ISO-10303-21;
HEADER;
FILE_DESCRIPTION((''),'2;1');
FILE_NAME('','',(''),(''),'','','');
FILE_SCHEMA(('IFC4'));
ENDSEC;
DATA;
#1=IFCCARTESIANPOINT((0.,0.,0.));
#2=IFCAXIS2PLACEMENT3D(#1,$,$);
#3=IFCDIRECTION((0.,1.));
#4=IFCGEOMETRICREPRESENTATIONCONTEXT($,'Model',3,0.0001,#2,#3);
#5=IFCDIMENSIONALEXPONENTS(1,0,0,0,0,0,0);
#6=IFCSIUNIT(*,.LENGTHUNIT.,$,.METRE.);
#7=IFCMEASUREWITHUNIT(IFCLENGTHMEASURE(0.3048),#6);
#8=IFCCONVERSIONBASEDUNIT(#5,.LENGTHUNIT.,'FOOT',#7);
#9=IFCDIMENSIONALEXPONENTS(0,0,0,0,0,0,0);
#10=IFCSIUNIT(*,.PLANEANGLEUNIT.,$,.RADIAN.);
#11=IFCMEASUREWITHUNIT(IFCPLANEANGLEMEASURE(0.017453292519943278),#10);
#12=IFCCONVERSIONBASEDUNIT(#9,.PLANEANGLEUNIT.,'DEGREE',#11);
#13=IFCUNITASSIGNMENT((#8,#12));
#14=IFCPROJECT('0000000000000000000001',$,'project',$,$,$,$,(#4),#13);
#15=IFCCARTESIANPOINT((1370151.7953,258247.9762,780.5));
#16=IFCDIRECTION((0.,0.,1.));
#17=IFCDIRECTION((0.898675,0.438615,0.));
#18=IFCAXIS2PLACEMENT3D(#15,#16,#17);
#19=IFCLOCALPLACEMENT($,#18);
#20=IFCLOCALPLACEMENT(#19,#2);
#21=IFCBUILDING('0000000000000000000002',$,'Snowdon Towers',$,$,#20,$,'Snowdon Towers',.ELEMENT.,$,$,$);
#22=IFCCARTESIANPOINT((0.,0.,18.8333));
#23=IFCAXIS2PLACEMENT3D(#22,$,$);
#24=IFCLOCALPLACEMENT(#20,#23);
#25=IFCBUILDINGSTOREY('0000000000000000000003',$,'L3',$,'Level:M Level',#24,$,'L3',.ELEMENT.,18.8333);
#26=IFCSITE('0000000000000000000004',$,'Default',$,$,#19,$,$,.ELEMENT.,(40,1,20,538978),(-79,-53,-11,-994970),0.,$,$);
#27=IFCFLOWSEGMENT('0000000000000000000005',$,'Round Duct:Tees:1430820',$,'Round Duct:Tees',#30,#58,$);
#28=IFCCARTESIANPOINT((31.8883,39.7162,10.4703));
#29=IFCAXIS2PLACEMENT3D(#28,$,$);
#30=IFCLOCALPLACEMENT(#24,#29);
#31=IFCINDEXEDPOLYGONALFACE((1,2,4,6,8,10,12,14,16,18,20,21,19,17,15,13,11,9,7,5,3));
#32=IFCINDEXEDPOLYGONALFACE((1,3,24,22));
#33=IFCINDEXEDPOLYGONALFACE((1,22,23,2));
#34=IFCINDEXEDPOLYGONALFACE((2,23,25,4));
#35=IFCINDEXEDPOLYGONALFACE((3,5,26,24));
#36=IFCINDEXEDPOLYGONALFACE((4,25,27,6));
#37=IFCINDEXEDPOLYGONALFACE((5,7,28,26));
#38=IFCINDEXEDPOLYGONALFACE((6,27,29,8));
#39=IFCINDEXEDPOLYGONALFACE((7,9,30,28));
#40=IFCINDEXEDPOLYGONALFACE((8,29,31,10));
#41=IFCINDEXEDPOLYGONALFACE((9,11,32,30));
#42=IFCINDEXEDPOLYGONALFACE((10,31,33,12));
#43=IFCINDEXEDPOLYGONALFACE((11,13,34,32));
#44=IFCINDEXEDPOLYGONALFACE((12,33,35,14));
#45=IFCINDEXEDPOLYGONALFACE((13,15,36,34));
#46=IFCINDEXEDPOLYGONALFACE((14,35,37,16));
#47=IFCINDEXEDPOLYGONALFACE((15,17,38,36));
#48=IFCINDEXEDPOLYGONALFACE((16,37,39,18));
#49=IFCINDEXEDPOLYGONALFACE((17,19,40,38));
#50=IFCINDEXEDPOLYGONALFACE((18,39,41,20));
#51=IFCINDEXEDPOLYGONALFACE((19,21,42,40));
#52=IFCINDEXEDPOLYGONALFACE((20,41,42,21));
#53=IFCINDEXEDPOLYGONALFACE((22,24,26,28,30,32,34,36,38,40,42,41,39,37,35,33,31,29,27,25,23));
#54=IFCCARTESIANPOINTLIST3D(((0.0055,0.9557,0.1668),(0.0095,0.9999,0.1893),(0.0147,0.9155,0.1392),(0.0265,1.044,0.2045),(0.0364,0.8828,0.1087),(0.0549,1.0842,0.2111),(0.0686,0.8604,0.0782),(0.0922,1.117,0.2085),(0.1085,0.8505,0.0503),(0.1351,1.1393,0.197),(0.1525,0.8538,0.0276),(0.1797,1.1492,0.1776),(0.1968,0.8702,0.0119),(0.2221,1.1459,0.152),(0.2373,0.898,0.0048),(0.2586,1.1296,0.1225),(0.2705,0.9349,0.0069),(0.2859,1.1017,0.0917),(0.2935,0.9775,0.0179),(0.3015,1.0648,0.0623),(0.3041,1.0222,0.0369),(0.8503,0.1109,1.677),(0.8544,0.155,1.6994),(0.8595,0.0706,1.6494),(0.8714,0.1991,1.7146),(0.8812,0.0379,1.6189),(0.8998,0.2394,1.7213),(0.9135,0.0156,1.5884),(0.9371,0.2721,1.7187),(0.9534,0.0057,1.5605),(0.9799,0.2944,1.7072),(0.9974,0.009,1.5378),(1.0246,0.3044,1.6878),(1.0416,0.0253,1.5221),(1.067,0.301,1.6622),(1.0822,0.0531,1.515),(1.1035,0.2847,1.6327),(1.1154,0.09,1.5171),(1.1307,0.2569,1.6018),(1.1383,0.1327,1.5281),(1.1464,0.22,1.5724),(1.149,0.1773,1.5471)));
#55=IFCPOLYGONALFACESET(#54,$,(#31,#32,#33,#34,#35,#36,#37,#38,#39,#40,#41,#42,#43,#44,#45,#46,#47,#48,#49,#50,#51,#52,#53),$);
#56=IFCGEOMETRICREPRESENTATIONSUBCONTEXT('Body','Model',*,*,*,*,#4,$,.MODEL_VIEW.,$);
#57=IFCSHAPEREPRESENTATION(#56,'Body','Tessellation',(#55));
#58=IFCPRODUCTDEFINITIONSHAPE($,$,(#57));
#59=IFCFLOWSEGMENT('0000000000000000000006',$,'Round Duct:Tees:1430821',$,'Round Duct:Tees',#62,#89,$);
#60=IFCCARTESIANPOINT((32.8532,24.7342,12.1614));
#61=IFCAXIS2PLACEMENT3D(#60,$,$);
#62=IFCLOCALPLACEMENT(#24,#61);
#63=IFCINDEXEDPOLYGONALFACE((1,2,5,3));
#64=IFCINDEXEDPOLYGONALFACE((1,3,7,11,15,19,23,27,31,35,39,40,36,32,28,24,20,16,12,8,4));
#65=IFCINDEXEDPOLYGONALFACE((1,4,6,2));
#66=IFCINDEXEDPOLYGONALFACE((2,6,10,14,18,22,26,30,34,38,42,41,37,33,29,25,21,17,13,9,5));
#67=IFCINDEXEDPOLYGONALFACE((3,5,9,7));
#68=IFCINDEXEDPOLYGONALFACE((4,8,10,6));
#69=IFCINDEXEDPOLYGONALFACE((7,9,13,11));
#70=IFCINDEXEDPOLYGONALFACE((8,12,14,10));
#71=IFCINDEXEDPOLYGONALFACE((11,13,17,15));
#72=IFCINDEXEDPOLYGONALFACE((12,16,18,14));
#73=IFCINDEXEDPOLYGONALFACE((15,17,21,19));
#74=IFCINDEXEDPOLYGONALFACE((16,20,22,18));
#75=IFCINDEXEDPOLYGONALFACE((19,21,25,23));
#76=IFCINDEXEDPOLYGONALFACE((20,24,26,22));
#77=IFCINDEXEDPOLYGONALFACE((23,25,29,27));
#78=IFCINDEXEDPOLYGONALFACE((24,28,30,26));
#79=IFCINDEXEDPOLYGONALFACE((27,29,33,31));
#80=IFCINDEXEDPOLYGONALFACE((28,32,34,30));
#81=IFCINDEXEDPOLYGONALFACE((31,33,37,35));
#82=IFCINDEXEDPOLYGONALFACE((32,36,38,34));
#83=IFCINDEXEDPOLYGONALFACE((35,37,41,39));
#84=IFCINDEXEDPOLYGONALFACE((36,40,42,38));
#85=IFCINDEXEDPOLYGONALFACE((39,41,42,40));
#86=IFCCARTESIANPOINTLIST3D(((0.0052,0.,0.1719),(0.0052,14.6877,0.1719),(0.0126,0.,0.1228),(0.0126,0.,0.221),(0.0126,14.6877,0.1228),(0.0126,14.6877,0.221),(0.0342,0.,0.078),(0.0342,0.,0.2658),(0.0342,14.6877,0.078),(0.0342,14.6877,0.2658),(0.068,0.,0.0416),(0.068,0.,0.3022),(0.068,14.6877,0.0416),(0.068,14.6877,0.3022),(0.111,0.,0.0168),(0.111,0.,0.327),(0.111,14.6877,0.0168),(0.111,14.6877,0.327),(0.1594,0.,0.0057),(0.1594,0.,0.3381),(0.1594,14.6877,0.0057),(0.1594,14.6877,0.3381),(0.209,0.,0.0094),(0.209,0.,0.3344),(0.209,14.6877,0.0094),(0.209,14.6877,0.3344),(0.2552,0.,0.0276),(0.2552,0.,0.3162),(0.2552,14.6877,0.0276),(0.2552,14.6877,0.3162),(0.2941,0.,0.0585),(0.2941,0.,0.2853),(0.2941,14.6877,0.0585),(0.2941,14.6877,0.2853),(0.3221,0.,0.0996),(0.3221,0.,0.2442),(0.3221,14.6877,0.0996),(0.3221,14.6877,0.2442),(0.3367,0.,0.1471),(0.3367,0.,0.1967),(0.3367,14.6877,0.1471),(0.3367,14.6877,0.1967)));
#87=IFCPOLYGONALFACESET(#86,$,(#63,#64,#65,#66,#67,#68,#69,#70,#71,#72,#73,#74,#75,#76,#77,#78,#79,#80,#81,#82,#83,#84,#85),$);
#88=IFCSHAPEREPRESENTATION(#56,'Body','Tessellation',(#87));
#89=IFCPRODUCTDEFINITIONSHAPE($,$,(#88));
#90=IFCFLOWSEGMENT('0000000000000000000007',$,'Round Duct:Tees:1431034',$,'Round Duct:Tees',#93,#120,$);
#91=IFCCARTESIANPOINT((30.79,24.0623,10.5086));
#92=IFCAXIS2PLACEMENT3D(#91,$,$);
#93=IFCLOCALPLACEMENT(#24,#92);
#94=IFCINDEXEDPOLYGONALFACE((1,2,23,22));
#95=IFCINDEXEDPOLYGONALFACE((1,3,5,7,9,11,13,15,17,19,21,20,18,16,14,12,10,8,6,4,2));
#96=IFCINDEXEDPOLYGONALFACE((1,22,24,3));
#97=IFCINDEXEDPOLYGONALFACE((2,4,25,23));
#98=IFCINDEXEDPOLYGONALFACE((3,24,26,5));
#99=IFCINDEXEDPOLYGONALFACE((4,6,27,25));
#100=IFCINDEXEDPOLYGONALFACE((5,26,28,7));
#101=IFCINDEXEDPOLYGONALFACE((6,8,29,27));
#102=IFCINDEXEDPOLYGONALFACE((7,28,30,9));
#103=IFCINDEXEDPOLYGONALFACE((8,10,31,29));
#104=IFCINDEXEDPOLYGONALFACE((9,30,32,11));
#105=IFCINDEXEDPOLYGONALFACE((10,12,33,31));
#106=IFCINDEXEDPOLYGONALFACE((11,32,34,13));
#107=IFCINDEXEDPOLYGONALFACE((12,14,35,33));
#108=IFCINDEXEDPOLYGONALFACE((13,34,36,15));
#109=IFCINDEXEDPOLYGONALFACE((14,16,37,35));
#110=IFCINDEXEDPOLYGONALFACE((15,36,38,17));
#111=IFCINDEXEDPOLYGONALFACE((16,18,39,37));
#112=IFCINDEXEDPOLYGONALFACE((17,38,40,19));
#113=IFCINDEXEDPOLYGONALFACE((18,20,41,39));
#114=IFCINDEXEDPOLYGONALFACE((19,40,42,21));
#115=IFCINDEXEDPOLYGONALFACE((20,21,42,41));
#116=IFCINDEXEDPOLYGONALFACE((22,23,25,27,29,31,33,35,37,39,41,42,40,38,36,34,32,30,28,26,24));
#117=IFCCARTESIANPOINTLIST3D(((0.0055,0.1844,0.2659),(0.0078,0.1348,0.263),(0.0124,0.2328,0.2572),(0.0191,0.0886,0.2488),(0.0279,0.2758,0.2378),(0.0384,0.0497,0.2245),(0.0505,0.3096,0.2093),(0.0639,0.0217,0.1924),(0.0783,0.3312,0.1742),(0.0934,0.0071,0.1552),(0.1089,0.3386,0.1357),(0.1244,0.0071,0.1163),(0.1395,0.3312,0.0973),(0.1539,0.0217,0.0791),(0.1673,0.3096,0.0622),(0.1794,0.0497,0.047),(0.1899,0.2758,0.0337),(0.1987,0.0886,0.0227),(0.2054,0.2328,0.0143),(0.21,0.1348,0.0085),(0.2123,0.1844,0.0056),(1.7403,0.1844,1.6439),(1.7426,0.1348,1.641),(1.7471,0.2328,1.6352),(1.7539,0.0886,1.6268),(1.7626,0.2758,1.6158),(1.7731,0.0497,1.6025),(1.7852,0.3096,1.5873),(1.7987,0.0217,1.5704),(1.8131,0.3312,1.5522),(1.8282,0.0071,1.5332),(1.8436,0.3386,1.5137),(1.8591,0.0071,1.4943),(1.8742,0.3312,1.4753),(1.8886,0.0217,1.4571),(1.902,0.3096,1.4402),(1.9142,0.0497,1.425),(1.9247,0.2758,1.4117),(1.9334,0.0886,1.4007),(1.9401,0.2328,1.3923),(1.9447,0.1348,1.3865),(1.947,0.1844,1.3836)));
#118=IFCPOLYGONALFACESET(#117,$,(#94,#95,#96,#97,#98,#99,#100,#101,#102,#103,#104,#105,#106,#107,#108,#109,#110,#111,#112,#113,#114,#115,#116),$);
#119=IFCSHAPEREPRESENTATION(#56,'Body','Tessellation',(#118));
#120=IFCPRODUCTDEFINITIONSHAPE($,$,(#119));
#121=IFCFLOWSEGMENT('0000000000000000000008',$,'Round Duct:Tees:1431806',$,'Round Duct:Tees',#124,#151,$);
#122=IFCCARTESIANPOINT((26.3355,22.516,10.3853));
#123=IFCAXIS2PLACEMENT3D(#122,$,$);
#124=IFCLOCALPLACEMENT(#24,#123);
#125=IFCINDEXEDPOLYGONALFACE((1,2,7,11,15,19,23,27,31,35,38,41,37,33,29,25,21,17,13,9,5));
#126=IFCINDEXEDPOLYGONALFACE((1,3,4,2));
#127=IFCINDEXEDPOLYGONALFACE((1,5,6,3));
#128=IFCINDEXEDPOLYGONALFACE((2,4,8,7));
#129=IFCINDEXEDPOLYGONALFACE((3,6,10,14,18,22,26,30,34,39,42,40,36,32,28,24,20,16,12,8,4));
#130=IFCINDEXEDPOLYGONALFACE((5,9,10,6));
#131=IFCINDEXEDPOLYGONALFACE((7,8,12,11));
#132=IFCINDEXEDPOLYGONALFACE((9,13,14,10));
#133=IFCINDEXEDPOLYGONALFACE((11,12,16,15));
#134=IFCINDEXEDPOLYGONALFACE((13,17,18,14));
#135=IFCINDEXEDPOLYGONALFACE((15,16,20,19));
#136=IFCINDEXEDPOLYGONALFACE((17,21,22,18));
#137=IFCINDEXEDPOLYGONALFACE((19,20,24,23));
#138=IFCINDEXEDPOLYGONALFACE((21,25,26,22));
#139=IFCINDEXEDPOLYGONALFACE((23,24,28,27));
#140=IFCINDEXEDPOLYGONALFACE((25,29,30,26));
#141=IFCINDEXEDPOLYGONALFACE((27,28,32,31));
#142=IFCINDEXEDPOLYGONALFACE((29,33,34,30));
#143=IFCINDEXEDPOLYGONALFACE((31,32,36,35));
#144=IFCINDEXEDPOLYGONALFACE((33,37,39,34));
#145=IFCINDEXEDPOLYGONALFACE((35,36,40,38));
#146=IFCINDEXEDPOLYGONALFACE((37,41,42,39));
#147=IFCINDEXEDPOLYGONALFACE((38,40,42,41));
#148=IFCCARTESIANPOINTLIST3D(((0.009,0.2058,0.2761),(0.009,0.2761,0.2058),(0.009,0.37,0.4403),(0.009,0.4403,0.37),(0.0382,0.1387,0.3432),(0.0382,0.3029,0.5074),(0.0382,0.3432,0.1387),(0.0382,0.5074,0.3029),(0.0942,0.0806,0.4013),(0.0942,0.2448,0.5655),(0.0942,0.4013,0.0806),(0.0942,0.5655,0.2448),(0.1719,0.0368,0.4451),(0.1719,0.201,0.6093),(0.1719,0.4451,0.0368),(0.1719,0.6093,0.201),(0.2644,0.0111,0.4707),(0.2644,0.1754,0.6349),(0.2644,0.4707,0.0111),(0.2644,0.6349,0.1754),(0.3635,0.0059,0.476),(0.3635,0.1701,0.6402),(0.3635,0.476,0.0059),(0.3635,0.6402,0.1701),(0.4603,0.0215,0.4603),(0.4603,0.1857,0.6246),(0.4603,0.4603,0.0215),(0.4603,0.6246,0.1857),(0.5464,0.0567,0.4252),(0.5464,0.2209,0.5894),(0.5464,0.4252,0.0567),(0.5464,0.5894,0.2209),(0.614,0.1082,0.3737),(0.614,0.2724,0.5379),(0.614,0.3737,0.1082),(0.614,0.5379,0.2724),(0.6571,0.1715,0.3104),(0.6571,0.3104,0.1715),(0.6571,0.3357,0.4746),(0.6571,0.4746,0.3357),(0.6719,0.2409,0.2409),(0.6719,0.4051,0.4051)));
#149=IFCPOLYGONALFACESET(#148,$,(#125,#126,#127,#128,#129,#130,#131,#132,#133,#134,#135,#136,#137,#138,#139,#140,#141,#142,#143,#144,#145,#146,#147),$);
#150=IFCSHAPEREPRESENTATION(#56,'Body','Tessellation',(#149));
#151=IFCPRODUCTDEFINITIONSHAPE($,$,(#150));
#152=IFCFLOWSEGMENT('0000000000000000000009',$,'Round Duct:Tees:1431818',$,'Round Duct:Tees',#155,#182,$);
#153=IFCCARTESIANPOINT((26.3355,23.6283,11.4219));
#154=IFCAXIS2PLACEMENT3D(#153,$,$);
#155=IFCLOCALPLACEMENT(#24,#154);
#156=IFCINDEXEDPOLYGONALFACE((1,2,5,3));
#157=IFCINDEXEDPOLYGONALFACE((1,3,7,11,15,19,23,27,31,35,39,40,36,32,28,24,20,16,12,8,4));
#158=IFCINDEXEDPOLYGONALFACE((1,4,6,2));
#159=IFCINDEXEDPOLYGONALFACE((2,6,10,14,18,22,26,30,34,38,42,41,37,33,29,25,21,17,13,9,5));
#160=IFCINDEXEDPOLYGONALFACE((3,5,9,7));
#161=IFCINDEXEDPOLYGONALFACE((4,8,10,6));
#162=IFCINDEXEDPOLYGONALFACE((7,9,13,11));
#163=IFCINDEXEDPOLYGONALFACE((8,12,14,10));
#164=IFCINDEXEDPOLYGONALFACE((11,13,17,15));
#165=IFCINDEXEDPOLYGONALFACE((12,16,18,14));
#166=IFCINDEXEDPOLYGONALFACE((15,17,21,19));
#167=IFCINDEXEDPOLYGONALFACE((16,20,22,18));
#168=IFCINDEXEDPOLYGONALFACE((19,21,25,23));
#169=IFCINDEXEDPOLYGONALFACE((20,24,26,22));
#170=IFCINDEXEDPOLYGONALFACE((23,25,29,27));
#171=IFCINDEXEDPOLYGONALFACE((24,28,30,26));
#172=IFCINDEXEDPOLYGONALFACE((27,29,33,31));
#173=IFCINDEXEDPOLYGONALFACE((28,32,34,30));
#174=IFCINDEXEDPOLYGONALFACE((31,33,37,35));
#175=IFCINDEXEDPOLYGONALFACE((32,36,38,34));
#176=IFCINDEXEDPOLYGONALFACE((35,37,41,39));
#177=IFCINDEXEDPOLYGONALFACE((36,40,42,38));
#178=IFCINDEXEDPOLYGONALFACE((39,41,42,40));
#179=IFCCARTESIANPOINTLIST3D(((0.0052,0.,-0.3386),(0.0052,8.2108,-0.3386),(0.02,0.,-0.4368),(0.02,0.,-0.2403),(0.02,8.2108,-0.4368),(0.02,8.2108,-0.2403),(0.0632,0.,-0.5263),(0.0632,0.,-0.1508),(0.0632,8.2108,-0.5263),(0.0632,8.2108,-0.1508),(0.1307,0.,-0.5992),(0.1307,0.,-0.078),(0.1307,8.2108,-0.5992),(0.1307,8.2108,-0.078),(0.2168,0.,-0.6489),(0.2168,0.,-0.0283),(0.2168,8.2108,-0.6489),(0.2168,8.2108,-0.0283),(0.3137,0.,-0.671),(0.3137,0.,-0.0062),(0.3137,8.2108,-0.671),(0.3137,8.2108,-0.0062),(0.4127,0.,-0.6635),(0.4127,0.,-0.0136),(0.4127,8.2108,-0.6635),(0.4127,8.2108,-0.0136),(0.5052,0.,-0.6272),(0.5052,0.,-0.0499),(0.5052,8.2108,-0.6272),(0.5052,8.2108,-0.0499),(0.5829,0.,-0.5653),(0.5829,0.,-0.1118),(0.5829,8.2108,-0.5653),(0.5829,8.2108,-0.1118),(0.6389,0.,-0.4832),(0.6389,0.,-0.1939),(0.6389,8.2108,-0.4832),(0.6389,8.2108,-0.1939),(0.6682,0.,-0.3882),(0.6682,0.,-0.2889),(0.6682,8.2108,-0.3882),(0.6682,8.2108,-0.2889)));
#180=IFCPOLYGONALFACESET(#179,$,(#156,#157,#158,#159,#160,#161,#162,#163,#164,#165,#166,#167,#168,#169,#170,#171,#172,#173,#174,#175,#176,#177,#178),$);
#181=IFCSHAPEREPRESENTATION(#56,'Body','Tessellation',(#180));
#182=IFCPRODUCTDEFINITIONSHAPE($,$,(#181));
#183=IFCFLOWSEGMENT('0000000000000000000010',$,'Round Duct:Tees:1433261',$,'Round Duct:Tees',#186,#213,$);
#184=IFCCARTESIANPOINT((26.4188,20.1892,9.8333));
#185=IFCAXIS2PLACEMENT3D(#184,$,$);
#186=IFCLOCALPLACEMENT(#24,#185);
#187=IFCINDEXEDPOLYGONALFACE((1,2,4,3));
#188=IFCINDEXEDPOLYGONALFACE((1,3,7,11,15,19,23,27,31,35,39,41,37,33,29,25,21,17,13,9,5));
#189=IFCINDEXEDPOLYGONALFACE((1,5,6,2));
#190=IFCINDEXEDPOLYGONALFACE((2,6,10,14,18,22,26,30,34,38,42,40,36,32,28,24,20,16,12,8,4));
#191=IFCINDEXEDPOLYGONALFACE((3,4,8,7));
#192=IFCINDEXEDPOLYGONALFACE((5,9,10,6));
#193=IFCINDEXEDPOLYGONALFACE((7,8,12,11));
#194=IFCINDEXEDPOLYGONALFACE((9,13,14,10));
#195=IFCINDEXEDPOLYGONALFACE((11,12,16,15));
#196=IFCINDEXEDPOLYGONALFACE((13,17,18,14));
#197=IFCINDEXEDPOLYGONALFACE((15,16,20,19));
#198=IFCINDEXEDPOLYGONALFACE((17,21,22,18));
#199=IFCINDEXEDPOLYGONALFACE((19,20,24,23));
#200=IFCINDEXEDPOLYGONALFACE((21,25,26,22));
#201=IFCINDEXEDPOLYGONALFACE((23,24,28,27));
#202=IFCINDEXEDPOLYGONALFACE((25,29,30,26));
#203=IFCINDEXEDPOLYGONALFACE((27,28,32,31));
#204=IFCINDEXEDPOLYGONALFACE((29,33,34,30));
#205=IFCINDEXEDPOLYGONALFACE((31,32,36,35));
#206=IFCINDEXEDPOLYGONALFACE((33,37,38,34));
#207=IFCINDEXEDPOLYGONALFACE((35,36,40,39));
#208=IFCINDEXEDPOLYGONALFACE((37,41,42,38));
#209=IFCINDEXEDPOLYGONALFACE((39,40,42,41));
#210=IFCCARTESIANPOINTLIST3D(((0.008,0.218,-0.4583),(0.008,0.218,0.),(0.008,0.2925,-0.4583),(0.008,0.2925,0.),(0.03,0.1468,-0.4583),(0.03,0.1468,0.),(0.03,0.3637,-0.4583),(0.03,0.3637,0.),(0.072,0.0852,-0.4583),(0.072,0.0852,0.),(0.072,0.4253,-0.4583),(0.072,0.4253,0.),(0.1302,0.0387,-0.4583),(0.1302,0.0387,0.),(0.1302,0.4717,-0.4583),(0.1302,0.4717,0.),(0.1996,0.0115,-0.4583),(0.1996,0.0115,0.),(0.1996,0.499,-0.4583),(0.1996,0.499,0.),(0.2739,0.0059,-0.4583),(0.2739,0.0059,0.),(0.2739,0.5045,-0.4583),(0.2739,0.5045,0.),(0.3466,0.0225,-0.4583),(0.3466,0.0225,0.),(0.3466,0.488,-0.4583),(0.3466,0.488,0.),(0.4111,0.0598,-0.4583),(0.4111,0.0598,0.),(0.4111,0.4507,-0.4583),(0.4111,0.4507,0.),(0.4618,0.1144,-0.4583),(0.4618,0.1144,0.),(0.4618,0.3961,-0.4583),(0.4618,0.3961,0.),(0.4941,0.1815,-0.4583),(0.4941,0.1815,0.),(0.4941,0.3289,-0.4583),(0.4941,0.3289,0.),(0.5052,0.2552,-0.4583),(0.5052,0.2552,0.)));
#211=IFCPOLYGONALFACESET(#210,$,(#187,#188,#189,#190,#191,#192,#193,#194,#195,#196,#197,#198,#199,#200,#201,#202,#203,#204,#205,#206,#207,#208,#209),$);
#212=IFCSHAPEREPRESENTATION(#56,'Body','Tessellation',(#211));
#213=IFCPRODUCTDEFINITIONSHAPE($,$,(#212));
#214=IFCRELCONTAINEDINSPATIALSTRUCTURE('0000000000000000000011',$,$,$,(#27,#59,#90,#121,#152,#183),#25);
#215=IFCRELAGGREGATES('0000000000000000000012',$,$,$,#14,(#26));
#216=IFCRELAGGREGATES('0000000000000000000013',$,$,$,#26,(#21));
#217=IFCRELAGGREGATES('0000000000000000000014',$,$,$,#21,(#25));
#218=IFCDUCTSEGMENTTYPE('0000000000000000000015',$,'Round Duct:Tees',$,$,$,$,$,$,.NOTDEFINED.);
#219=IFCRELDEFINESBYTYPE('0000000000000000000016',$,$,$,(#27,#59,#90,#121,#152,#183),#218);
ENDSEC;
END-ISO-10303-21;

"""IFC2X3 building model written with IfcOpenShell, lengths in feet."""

from ifc_helpers import new_model, entity, si_unit, converted_unit, direction, frame, frame_2d, origin, place, context, subcontext, project, spatial, circle, extrude, type_object, element, save


model = new_model("IFC2X3")

# Units and contexts
model_context = context("Model", 3, precision=0.0001, world=origin(), true_north=direction((0.0, 1.0)))
body_context = subcontext(model_context, "Body", "Model", "MODEL_VIEW")
ifc_project = project(units=[converted_unit("LENGTHUNIT", "FOOT", entity("IfcLengthMeasure", 0.3048), si_unit("LENGTHUNIT", "METRE"), dimensions=[1, 0, 0, 0, 0, 0, 0]), converted_unit("PLANEANGLEUNIT", "DEGREE", entity("IfcPlaneAngleMeasure", 0.017453292519943278), si_unit("PLANEANGLEUNIT", "RADIAN"), dimensions=[0, 0, 0, 0, 0, 0, 0])], contexts=[model_context])

# Site, building, storey
site_placement = place(None, frame((1370151.7953, 258247.9762, 780.5), z_axis=(0.0, 0.0, 1.0), x_axis=(0.898675, 0.438615, 0.0)))
site = spatial("IfcSite", under=ifc_project, at=site_placement, Name="Default", CompositionType="ELEMENT", RefLatitude=(40, 1, 20, 538978), RefLongitude=(-79, -53, -11, -994970), RefElevation=0.0)
building_placement = place(site_placement, origin())
building = spatial("IfcBuilding", under=site, at=building_placement, Name="Snowdon Towers", LongName="Snowdon Towers", CompositionType="ELEMENT")
storey_placement = place(building_placement, frame((0.0, 0.0, 18.8333)))
storey = spatial("IfcBuildingStorey", under=building, at=storey_placement, Name="L3", ObjectType="Level:M Level", LongName="L3", CompositionType="ELEMENT", Elevation=18.8333)

# Flow segments
duct_segment_type = type_object("IfcDuctSegmentType", Name="Round Duct:Tees", PredefinedType="NOTDEFINED")
flow_segment_1_placement = place(storey_placement, frame((31.8883, 39.7162, 10.4703)))
element("IfcFlowSegment", 1, at=flow_segment_1_placement, inside=storey, type_object=duct_segment_type, Name="Round Duct:Tees:1430820", ObjectType="Round Duct:Tees", context=body_context, shape_type="SweptSolid", body=[
    extrude(circle(Radius=0.1667, at=frame_2d((0.0, 0.0), x_axis=(1.0, 0.0))), frame((0.155, 0.9999, 0.1079), z_axis=(0.438735, -0.438735, 0.784234), x_axis=(-0.872713, 0.0, 0.488234)), (0.0, 0.0, 1.0), 1.9257),
])
flow_segment_2_placement = place(storey_placement, frame((32.8532, 24.7342, 12.1614)))
element("IfcFlowSegment", 2, at=flow_segment_2_placement, inside=storey, type_object=duct_segment_type, Name="Round Duct:Tees:1430821", ObjectType="Round Duct:Tees", context=body_context, shape_type="SweptSolid", body=[
    extrude(circle(Radius=0.1667, at=frame_2d((0.0, 0.0), x_axis=(1.0, 0.0))), frame((0.1719, 0.0, 0.1719), z_axis=(0.0, 1.0, 0.0), x_axis=(-1.0, 0.0, 0.0)), (0.0, 0.0, 1.0), 14.6877),
])
flow_segment_3_placement = place(storey_placement, frame((30.79, 24.0623, 10.5086)))
element("IfcFlowSegment", 3, at=flow_segment_3_placement, inside=storey, type_object=duct_segment_type, Name="Round Duct:Tees:1431034", ObjectType="Round Duct:Tees", context=body_context, shape_type="SweptSolid", body=[
    extrude(circle(Radius=0.1667, at=frame_2d((0.0, 0.0), x_axis=(1.0, 0.0))), frame((0.1089, 0.1719, 0.1357), z_axis=(0.78302, 0.0, 0.621996), x_axis=(0.0, 1.0, 0.0)), (0.0, 0.0, 1.0), 2.2155),
])
flow_segment_4_placement = place(storey_placement, frame((26.3355, 22.516, 10.3853)))
element("IfcFlowSegment", 4, at=flow_segment_4_placement, inside=storey, type_object=duct_segment_type, Name="Round Duct:Tees:1431806", ObjectType="Round Duct:Tees", context=body_context, shape_type="SweptSolid", body=[
    extrude(circle(Radius=0.3333, at=frame_2d((0.0, 0.0), x_axis=(1.0, 0.0))), frame((0.3386, 0.2409, 0.2409), z_axis=(0.0, 0.707107, 0.707107), x_axis=(1.0, 0.0, 0.0)), (0.0, 0.0, 1.0), 0.2322),
])
flow_segment_5_placement = place(storey_placement, frame((26.3355, 23.6283, 11.4219)))
element("IfcFlowSegment", 5, at=flow_segment_5_placement, inside=storey, type_object=duct_segment_type, Name="Round Duct:Tees:1431818", ObjectType="Round Duct:Tees", context=body_context, shape_type="SweptSolid", body=[
    extrude(circle(Radius=0.3333, at=frame_2d((0.0, 0.0), x_axis=(1.0, 0.0))), frame((0.3386, 0.0, -0.3386), z_axis=(0.0, 1.0, 0.0), x_axis=(-1.0, 0.0, 0.0)), (0.0, 0.0, 1.0), 8.2108),
])
flow_segment_6_placement = place(storey_placement, frame((26.4188, 20.1892, 9.8333)))
element("IfcFlowSegment", 6, at=flow_segment_6_placement, inside=storey, type_object=duct_segment_type, Name="Round Duct:Tees:1433261", ObjectType="Round Duct:Tees", context=body_context, shape_type="SweptSolid", body=[
    extrude(circle(Radius=0.25, at=frame_2d((0.0, 0.0), x_axis=(1.0, 0.0))), frame((0.2552, 0.2552, -0.4583)), (0.0, 0.0, 1.0), 0.4583),
])

save(model, "model.ifc")
